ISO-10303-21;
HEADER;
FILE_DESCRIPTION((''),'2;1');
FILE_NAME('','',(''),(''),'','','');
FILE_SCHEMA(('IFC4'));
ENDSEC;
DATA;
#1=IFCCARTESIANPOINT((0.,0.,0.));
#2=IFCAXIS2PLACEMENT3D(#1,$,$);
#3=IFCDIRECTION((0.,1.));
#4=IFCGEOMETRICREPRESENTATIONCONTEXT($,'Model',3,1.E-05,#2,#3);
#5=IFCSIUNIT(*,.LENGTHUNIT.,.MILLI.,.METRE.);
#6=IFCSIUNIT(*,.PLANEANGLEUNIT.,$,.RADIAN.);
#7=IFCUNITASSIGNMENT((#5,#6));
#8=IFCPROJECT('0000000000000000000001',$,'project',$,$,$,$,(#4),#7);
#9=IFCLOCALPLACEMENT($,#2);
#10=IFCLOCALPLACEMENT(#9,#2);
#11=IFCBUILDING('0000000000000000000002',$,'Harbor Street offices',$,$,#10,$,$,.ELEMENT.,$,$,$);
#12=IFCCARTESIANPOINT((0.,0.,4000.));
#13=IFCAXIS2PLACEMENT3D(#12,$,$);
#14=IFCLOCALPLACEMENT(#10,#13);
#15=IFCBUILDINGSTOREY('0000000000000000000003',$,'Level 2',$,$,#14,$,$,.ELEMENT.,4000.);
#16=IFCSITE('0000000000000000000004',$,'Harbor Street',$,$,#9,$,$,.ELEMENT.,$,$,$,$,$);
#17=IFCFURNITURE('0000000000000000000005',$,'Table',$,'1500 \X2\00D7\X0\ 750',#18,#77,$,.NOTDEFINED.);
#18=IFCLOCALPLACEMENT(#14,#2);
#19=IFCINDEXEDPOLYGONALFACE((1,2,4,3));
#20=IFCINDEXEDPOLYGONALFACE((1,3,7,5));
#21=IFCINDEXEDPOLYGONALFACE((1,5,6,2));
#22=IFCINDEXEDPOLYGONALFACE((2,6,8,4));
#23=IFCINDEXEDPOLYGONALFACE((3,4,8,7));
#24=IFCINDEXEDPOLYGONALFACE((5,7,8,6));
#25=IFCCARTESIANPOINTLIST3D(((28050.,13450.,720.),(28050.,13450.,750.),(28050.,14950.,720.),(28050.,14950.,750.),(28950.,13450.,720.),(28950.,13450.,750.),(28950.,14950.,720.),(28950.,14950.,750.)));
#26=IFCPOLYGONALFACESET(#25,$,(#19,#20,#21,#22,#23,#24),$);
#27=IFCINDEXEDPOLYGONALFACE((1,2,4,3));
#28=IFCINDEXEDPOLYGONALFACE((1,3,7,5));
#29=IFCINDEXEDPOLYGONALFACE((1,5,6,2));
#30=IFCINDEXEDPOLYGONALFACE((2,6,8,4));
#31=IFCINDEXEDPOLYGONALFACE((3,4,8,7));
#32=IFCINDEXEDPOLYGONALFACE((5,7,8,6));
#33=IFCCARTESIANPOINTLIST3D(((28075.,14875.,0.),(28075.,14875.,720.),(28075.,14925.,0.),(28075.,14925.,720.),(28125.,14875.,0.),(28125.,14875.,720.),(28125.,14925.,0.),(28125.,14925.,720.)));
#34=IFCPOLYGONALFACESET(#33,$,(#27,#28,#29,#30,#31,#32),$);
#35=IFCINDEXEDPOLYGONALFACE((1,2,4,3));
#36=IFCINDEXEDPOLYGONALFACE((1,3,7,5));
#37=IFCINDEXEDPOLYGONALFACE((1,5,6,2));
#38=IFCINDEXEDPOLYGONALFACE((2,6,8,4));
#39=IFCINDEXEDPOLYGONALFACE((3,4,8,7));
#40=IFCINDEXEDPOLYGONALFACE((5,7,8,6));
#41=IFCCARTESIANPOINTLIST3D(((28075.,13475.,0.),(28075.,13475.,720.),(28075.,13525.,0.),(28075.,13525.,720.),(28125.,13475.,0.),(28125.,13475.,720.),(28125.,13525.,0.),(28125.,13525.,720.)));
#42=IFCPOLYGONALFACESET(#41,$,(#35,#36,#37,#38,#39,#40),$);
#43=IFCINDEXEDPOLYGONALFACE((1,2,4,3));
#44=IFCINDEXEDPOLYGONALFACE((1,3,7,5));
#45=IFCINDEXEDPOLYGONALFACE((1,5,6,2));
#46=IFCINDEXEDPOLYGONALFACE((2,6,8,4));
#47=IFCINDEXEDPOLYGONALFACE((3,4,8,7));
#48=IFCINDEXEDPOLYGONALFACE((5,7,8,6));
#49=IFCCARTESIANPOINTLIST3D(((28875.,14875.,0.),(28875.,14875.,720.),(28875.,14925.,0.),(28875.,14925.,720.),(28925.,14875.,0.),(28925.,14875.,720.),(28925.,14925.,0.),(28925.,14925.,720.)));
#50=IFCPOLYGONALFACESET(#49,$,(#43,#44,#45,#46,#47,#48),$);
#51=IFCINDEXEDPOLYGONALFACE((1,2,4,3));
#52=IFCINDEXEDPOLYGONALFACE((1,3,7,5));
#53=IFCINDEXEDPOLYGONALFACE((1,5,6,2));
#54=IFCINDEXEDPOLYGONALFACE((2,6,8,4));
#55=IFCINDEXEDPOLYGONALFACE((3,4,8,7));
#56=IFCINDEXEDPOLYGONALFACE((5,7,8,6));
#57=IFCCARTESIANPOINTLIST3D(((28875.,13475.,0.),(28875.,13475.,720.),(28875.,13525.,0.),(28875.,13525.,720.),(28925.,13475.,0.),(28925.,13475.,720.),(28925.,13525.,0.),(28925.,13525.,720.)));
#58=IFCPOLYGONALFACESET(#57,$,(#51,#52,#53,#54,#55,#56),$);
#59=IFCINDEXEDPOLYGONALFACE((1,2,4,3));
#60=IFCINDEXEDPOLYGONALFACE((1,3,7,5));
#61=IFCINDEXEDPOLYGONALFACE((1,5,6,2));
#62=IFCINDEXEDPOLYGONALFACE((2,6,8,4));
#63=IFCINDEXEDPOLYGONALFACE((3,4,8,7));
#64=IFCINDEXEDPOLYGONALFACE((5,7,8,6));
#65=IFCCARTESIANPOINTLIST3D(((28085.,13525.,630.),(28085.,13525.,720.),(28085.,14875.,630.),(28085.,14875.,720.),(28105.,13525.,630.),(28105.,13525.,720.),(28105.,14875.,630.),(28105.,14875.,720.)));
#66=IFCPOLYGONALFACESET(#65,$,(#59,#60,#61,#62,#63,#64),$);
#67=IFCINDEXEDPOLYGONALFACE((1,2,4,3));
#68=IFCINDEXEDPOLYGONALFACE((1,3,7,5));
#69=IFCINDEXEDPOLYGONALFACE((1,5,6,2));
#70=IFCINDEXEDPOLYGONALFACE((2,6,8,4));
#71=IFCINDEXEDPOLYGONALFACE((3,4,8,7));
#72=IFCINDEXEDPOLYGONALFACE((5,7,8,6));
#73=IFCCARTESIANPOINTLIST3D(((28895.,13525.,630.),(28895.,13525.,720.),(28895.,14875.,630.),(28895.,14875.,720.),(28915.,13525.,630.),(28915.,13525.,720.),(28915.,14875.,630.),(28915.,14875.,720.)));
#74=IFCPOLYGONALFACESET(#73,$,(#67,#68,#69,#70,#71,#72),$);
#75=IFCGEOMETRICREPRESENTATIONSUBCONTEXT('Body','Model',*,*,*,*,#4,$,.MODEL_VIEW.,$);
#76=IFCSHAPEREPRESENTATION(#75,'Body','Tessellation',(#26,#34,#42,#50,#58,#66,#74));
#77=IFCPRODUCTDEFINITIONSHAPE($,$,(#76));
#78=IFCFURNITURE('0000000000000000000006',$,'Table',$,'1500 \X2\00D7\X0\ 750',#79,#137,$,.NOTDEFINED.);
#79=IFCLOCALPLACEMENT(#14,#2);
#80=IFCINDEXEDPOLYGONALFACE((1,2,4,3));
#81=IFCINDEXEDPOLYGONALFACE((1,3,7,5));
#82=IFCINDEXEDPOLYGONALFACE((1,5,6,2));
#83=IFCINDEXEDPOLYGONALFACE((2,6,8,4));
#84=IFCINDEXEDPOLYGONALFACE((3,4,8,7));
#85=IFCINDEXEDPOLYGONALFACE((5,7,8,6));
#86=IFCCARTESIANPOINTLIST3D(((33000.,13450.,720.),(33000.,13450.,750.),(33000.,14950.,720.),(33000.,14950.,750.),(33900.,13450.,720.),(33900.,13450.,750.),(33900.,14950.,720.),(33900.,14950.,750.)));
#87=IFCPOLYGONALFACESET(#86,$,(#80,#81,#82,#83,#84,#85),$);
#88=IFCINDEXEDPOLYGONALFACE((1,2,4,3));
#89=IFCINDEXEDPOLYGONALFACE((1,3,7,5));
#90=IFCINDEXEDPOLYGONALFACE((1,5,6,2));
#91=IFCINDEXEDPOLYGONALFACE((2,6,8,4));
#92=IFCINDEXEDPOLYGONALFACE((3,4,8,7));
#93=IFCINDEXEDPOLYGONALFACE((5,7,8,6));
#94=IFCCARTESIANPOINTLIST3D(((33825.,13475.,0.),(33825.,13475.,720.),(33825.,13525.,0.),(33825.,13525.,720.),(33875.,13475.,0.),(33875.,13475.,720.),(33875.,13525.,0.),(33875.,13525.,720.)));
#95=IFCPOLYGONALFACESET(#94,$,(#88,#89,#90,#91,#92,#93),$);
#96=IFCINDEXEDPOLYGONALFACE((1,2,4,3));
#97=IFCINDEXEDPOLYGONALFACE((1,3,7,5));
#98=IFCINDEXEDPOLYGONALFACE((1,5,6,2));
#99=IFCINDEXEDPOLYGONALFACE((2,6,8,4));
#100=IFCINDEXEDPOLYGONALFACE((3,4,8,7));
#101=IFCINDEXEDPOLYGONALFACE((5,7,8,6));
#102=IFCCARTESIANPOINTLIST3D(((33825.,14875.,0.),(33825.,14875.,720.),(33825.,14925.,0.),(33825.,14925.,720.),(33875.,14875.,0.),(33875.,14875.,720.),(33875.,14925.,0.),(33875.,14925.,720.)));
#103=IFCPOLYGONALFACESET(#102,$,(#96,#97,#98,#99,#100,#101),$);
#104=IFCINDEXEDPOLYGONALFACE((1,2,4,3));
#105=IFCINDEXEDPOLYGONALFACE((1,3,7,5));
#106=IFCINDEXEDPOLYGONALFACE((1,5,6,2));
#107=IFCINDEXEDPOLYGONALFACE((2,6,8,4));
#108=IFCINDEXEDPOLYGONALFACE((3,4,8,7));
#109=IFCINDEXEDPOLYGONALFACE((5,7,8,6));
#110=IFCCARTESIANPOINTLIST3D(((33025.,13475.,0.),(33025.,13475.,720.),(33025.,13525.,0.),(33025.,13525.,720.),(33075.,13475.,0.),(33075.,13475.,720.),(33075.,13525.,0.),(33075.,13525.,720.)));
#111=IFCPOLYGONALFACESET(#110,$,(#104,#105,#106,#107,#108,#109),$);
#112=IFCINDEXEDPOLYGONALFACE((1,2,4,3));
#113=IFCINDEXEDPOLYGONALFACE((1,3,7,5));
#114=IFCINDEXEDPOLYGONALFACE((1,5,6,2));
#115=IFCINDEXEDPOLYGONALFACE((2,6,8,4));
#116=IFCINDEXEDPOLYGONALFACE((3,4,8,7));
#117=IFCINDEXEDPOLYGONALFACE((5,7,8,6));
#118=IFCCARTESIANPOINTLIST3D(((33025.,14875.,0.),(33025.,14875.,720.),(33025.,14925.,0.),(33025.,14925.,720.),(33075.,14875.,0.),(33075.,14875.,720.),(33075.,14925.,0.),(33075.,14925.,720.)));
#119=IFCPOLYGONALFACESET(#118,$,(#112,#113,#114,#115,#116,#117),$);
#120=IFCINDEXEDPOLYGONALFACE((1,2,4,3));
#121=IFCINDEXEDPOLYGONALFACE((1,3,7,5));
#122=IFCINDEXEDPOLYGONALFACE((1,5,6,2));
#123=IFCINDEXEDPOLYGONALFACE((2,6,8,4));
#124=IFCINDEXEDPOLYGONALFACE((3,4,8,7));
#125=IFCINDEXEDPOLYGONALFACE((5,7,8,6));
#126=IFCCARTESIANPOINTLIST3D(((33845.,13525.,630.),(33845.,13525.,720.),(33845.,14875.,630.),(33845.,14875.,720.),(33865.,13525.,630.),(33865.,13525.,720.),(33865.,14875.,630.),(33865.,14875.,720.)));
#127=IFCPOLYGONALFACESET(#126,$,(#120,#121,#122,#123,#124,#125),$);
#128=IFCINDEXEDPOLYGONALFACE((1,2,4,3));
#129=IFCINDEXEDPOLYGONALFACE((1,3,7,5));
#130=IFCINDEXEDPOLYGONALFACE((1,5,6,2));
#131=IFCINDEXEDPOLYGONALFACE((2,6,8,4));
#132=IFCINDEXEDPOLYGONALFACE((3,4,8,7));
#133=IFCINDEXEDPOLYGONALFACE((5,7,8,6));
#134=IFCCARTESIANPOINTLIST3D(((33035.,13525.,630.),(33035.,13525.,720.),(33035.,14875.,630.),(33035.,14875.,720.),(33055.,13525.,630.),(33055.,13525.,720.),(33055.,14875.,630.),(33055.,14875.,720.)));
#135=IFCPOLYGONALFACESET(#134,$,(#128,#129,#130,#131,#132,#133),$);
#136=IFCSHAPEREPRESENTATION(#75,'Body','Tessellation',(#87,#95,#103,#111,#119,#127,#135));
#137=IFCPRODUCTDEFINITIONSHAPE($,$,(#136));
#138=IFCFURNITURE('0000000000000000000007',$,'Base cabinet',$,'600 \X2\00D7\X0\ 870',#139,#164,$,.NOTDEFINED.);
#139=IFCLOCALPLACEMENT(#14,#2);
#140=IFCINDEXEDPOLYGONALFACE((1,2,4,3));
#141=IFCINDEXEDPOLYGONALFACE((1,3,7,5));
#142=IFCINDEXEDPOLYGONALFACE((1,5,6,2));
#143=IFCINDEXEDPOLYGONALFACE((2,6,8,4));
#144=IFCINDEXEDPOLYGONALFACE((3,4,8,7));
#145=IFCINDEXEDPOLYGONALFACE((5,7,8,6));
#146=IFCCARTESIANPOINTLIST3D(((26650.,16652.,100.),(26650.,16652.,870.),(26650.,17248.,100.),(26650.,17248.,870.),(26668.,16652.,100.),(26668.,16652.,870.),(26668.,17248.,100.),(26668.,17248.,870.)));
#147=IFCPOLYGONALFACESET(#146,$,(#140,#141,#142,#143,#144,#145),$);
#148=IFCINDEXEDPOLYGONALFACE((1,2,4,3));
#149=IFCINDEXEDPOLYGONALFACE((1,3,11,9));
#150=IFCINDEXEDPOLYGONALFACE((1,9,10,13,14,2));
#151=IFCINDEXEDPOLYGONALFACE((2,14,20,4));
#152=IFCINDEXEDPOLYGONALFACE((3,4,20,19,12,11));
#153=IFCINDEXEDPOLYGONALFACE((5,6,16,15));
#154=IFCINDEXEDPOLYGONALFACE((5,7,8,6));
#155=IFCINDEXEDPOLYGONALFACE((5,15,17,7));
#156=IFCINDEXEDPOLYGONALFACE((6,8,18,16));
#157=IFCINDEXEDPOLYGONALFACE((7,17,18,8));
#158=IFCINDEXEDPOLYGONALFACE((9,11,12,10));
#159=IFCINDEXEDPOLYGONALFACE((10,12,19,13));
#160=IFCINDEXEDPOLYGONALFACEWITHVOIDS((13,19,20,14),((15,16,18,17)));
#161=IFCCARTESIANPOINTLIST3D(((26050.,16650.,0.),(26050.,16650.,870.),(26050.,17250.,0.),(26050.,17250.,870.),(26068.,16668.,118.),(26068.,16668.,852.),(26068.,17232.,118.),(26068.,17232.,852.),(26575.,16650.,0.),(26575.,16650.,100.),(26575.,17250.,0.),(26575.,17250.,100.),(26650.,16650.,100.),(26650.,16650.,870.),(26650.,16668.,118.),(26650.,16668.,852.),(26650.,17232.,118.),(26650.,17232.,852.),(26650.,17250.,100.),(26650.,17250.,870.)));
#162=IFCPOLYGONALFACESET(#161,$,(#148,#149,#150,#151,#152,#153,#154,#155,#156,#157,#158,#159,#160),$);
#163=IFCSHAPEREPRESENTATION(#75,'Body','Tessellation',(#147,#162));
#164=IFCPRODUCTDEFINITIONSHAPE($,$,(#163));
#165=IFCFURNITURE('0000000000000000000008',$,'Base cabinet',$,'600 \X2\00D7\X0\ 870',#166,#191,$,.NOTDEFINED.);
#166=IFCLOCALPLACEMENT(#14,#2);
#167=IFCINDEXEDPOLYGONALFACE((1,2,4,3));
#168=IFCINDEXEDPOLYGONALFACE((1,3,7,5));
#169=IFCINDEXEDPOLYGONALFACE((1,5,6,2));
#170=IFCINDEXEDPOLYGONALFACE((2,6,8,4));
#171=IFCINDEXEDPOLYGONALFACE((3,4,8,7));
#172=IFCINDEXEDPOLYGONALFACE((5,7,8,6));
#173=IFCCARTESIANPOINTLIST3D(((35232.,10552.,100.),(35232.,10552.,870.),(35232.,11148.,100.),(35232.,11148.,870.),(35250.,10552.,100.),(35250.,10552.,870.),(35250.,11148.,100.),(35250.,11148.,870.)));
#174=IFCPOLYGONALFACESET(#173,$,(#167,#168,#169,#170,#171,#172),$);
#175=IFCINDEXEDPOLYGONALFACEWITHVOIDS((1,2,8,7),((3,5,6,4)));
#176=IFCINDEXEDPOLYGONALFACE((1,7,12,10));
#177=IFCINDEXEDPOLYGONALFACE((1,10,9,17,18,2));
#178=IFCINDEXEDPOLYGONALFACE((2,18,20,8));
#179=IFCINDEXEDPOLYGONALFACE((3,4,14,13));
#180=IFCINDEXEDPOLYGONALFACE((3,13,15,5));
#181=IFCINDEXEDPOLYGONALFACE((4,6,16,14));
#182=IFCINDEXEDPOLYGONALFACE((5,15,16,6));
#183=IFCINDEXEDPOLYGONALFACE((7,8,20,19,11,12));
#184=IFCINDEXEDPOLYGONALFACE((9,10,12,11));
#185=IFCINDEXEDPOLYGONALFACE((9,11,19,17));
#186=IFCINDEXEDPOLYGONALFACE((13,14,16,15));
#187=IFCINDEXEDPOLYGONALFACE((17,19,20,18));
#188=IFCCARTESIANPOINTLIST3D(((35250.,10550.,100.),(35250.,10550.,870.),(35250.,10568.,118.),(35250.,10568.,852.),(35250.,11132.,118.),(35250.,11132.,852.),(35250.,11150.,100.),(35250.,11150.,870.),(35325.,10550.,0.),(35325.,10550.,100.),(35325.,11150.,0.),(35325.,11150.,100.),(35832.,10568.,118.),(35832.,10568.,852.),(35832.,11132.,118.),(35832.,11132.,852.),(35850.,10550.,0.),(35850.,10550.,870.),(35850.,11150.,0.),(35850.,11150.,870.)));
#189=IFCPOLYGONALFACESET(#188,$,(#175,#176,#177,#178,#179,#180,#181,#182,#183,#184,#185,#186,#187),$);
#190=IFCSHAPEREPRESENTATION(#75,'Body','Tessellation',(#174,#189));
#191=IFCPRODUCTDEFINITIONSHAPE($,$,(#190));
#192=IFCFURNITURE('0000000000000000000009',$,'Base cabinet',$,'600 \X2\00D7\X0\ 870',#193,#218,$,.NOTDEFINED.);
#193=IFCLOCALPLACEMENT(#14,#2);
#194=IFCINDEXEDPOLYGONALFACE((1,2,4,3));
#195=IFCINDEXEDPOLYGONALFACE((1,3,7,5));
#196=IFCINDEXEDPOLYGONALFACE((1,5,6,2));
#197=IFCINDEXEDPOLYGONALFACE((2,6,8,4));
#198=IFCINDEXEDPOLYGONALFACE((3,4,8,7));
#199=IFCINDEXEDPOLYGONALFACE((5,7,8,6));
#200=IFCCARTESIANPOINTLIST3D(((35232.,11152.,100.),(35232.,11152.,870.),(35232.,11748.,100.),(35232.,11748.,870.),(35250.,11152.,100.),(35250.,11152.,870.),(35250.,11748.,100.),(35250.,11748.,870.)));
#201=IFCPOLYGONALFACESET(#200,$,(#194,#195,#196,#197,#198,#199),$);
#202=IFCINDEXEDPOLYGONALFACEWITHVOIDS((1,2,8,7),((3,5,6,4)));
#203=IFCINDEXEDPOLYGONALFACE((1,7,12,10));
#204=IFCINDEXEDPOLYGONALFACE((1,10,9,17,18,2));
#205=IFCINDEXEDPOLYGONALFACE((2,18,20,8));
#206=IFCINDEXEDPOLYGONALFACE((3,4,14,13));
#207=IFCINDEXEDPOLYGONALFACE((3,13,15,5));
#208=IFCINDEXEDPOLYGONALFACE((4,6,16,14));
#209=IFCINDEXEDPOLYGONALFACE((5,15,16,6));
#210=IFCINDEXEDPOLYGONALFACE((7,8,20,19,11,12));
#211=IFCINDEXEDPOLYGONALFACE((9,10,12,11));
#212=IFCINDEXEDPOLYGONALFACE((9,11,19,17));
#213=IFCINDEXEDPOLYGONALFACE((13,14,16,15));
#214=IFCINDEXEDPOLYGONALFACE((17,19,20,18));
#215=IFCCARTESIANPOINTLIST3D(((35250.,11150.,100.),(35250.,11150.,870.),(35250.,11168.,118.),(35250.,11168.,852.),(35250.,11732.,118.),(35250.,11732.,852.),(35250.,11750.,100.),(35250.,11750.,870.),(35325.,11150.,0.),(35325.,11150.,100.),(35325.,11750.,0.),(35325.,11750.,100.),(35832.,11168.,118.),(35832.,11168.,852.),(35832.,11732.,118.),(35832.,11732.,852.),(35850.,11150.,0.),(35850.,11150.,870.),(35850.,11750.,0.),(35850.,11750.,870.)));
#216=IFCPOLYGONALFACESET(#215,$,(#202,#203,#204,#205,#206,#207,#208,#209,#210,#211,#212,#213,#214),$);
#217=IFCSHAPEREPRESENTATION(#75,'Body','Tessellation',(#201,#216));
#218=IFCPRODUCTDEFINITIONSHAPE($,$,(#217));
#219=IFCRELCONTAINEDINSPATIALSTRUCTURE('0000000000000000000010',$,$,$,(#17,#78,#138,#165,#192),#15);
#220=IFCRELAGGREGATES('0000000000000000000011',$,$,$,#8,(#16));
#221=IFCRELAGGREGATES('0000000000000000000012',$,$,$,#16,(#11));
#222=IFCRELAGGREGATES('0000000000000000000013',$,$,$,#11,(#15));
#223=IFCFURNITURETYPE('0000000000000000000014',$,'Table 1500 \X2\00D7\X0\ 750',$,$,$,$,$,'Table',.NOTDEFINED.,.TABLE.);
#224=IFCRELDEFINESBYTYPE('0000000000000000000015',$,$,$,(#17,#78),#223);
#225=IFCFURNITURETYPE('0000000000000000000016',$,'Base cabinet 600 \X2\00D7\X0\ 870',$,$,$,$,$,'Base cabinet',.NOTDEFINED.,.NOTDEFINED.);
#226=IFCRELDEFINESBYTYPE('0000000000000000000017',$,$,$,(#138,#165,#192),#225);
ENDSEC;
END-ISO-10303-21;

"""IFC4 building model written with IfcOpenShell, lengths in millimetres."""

from ifc_helpers import new_model, entity, si_unit, direction, frame, origin, place, context, subcontext, project, spatial, polyline, outline, extrude, source, transform, mapped, type_object, type_shapes, element, save


model = new_model("IFC4")

# Units and contexts
model_context = context("Model", 3, precision=1e-05, world=origin(), true_north=direction((0.0, 1.0)))
body_context = subcontext(model_context, "Body", "Model", "MODEL_VIEW")
ifc_project = project(units=[si_unit("LENGTHUNIT", "METRE", prefix="MILLI"), si_unit("PLANEANGLEUNIT", "RADIAN")], contexts=[model_context])

# Site, building, storey
site_placement = place(None, origin())
site = spatial("IfcSite", under=ifc_project, at=site_placement, Name="Harbor Street", CompositionType="ELEMENT")
building_placement = place(site_placement, origin())
building = spatial("IfcBuilding", under=site, at=building_placement, Name="Harbor Street offices", CompositionType="ELEMENT")
storey_placement = place(building_placement, frame((0.0, 0.0, 4000.0)))
storey = spatial("IfcBuildingStorey", under=building, at=storey_placement, Name="Level 2", CompositionType="ELEMENT", Elevation=4000.0)

# Furniture
furniture_type_1 = type_object("IfcFurnitureType", Name="Table 1500 × 750", ElementType="Table", AssemblyPlace="NOTDEFINED", PredefinedType="TABLE")
shared_shape_1 = source(origin(), body_context, "Body", "SweptSolid", [
    extrude(outline(polyline([(-750.0, -450.0), (750.0, -450.0), (750.0, 450.0), (-750.0, 450.0), (-750.0, -450.0)])), frame((0.0, 0.0, 720.0)), (0.0, 0.0, 1.0), 30.0),
    extrude(outline(polyline([(-725.0, -425.0), (-675.0, -425.0), (-675.0, -375.0), (-725.0, -375.0), (-725.0, -425.0)])), origin(), (0.0, 0.0, 1.0), 720.0),
    extrude(outline(polyline([(675.0, -425.0), (725.0, -425.0), (725.0, -375.0), (675.0, -375.0), (675.0, -425.0)])), origin(), (0.0, 0.0, 1.0), 720.0),
    extrude(outline(polyline([(-725.0, 375.0), (-675.0, 375.0), (-675.0, 425.0), (-725.0, 425.0), (-725.0, 375.0)])), origin(), (0.0, 0.0, 1.0), 720.0),
    extrude(outline(polyline([(675.0, 375.0), (725.0, 375.0), (725.0, 425.0), (675.0, 425.0), (675.0, 375.0)])), origin(), (0.0, 0.0, 1.0), 720.0),
    extrude(outline(polyline([(-675.0, -415.0), (675.0, -415.0), (675.0, -395.0), (-675.0, -395.0), (-675.0, -415.0)])), frame((0.0, 0.0, 630.0)), (0.0, 0.0, 1.0), 90.0),
    extrude(outline(polyline([(-675.0, 395.0), (675.0, 395.0), (675.0, 415.0), (-675.0, 415.0), (-675.0, 395.0)])), frame((0.0, 0.0, 630.0)), (0.0, 0.0, 1.0), 90.0),
])
type_shapes(furniture_type_1, [shared_shape_1])
for number, where, z_axis, x_axis, name in (
    (1, (28500.0, 14200.0, 0.0), (0.0, 0.0, 1.0), (0.0, -1.0, 0.0), "Table"),
    (2, (33450.0, 14200.0, 0.0), (0.0, 0.0, 1.0), (0.0, 1.0, 0.0), "Table"),
):
    element("IfcFurniture", number, at=place(storey_placement, frame(where, z_axis=z_axis, x_axis=x_axis)), inside=storey, type_object=furniture_type_1, Name=name, ObjectType="1500 × 750", PredefinedType="NOTDEFINED", context=body_context, shape_type="MappedRepresentation", body=[
        mapped(shared_shape_1, transform((0.0, 0.0, 0.0))),
    ])
furniture_type_2 = type_object("IfcFurnitureType", Name="Base cabinet 600 × 870", ElementType="Base cabinet", AssemblyPlace="NOTDEFINED", PredefinedType="NOTDEFINED")
cartesian_point_1 = entity("IfcCartesianPoint", [-300.0, 0.0])
cartesian_point_2 = entity("IfcCartesianPoint", [-282.0, -1.0])
cartesian_point_3 = entity("IfcCartesianPoint", [-301.0, -1.0])
shared_shape_2 = source(origin(), body_context, "Body", "SolidModel", [
    extrude(outline(polyline([(-298.0, -18.0), (298.0, -18.0), (298.0, 0.0), (-298.0, 0.0), (-298.0, -18.0)])), frame((0.0, 0.0, 100.0)), (0.0, 0.0, 1.0), 770.0),
    entity("IfcCsgSolid", entity("IfcBooleanResult", "DIFFERENCE", entity("IfcBooleanResult", "DIFFERENCE", entity("IfcExtrudedAreaSolid", entity("IfcArbitraryClosedProfileDef", "AREA", None, entity("IfcPolyline", [cartesian_point_1, entity("IfcCartesianPoint", [300.0, 0.0]), entity("IfcCartesianPoint", [300.0, 600.0]), entity("IfcCartesianPoint", [-300.0, 600.0]), cartesian_point_1])), entity("IfcAxis2Placement3D", entity("IfcCartesianPoint", [0.0, 0.0, 0.0])), entity("IfcDirection", [0.0, 0.0, 1.0]), 870.0), entity("IfcExtrudedAreaSolid", entity("IfcArbitraryClosedProfileDef", "AREA", None, entity("IfcPolyline", [cartesian_point_2, entity("IfcCartesianPoint", [282.0, -1.0]), entity("IfcCartesianPoint", [282.0, 582.0]), entity("IfcCartesianPoint", [-282.0, 582.0]), cartesian_point_2])), entity("IfcAxis2Placement3D", entity("IfcCartesianPoint", [0.0, 0.0, 118.0])), entity("IfcDirection", [0.0, 0.0, 1.0]), 734.0)), entity("IfcExtrudedAreaSolid", entity("IfcArbitraryClosedProfileDef", "AREA", None, entity("IfcPolyline", [cartesian_point_3, entity("IfcCartesianPoint", [301.0, -1.0]), entity("IfcCartesianPoint", [301.0, 75.0]), entity("IfcCartesianPoint", [-301.0, 75.0]), cartesian_point_3])), entity("IfcAxis2Placement3D", entity("IfcCartesianPoint", [0.0, 0.0, -1.0])), entity("IfcDirection", [0.0, 0.0, 1.0]), 101.0))),
])
type_shapes(furniture_type_2, [shared_shape_2])
for number, where, z_axis, x_axis, name in (
    (3, (26650.0, 16950.0, 0.0), (0.0, 0.0, 1.0), (0.0, 1.0, 0.0), "Base cabinet"),
    (4, (35250.0, 10850.0, 0.0), (0.0, 0.0, 1.0), (0.0, -1.0, 0.0), "Base cabinet"),
    (5, (35250.0, 11450.0, 0.0), (0.0, 0.0, 1.0), (0.0, -1.0, 0.0), "Base cabinet"),
):
    element("IfcFurniture", number, at=place(storey_placement, frame(where, z_axis=z_axis, x_axis=x_axis)), inside=storey, type_object=furniture_type_2, Name=name, ObjectType="600 × 870", PredefinedType="NOTDEFINED", context=body_context, shape_type="MappedRepresentation", body=[
        mapped(shared_shape_2, transform((0.0, 0.0, 0.0))),
    ])

save(model, "model.ifc")
